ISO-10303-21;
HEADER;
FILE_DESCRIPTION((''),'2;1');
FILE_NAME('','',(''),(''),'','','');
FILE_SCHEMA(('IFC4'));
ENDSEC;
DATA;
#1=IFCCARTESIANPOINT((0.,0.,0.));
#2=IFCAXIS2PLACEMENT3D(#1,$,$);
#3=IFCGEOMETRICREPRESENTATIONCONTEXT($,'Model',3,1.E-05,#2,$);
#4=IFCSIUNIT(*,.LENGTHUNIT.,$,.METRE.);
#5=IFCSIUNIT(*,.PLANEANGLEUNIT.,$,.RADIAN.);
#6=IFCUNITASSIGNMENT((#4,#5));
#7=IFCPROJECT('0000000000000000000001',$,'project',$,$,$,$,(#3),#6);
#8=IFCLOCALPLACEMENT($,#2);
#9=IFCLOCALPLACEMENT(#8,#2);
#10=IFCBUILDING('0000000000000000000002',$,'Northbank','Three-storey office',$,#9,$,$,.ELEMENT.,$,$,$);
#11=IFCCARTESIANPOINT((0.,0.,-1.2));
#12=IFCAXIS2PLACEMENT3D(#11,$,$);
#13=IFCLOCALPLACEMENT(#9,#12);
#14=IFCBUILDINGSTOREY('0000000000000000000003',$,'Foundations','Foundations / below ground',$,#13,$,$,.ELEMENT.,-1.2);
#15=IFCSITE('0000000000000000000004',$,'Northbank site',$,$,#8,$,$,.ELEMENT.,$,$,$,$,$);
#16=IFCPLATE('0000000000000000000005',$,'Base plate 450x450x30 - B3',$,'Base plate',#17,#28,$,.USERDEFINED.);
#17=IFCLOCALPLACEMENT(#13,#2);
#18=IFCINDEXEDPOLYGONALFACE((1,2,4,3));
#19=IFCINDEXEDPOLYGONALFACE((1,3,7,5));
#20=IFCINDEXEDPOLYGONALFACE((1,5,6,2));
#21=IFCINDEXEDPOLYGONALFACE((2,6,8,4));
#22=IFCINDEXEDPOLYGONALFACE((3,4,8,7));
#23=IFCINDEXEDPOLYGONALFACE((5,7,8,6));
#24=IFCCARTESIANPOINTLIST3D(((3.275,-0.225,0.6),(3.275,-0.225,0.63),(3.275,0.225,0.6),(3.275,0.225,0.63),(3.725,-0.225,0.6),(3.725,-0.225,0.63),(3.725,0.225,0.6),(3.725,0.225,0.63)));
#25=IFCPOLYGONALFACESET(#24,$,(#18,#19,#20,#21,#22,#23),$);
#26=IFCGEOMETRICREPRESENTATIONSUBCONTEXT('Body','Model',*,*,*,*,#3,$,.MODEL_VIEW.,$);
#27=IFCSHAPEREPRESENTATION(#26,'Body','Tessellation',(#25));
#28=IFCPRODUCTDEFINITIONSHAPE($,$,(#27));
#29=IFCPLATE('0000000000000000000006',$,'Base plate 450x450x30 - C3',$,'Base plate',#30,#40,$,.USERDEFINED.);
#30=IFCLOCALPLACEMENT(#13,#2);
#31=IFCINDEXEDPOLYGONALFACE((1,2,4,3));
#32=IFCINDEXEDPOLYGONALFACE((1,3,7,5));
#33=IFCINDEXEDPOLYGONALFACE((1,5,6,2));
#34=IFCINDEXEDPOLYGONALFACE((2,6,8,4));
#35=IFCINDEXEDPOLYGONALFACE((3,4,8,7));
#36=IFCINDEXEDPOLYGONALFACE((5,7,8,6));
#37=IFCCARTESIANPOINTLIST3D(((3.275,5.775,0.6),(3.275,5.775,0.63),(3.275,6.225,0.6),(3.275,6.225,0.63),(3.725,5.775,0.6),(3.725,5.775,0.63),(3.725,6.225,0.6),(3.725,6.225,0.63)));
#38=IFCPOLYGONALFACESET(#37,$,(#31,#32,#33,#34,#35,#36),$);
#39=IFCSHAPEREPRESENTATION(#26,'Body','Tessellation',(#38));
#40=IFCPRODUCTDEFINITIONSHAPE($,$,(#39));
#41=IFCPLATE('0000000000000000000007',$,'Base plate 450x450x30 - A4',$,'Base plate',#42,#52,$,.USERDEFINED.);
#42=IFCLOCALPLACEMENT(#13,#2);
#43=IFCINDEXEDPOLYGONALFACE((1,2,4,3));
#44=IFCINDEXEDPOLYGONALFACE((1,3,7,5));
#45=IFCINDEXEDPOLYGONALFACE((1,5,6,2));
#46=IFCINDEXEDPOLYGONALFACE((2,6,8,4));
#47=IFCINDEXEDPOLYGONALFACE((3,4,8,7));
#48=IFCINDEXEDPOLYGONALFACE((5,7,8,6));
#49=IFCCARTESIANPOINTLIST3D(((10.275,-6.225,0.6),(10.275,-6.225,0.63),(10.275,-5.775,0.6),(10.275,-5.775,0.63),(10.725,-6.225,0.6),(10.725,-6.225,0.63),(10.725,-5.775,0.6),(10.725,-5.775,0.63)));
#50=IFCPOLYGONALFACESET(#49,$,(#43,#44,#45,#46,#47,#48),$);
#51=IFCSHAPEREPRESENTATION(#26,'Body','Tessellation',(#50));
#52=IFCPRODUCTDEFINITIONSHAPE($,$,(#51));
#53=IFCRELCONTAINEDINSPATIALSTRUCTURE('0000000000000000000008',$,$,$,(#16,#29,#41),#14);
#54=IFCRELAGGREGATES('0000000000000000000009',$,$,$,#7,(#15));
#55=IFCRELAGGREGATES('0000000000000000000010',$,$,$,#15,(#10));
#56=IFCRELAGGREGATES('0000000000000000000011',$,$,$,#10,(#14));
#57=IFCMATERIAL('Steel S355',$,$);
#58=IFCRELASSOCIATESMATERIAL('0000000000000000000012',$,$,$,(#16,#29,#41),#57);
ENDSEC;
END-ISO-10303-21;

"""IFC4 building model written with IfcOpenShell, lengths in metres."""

from ifc_helpers import new_model, si_unit, frame, origin, place, context, subcontext, project, spatial, rectangle, extrude, material, element, save


model = new_model("IFC4")

# Units and contexts
model_context = context("Model", 3, precision=1e-05, world=origin())
body_context = subcontext(model_context, "Body", "Model", "MODEL_VIEW")
ifc_project = project(units=[si_unit("LENGTHUNIT", "METRE"), si_unit("PLANEANGLEUNIT", "RADIAN")], contexts=[model_context])

# Site, building, storey
site_placement = place(None, origin())
site = spatial("IfcSite", under=ifc_project, at=site_placement, Name="Northbank site", CompositionType="ELEMENT")
building_placement = place(site_placement, origin())
building = spatial("IfcBuilding", under=site, at=building_placement, Name="Northbank", Description="Three-storey office", CompositionType="ELEMENT")
storey_placement = place(building_placement, frame((0.0, 0.0, -1.2)))
storey = spatial("IfcBuildingStorey", under=building, at=storey_placement, Name="Foundations", Description="Foundations / below ground", CompositionType="ELEMENT", Elevation=-1.2)

# Plates
ifc_material_1 = material(Name="Steel S355")
plate_1_placement = place(storey_placement, frame((0.0, 0.0, 1.2)))
element("IfcPlate", 1, at=plate_1_placement, inside=storey, material=ifc_material_1, Name="Base plate 450x450x30 - B3", ObjectType="Base plate", PredefinedType="USERDEFINED", context=body_context, shape_type="SweptSolid", body=[
    extrude(rectangle(XDim=0.45, YDim=0.45), frame((3.5, 0.0, -0.6)), (0.0, 0.0, 1.0), 0.03),
])
plate_2_placement = place(storey_placement, frame((0.0, 0.0, 1.2)))
element("IfcPlate", 2, at=plate_2_placement, inside=storey, material=ifc_material_1, Name="Base plate 450x450x30 - C3", ObjectType="Base plate", PredefinedType="USERDEFINED", context=body_context, shape_type="SweptSolid", body=[
    extrude(rectangle(XDim=0.45, YDim=0.45), frame((3.5, 6.0, -0.6)), (0.0, 0.0, 1.0), 0.03),
])
plate_3_placement = place(storey_placement, frame((0.0, 0.0, 1.2)))
element("IfcPlate", 3, at=plate_3_placement, inside=storey, material=ifc_material_1, Name="Base plate 450x450x30 - A4", ObjectType="Base plate", PredefinedType="USERDEFINED", context=body_context, shape_type="SweptSolid", body=[
    extrude(rectangle(XDim=0.45, YDim=0.45), frame((10.5, -6.0, -0.6)), (0.0, 0.0, 1.0), 0.03),
])

save(model, "model.ifc")
